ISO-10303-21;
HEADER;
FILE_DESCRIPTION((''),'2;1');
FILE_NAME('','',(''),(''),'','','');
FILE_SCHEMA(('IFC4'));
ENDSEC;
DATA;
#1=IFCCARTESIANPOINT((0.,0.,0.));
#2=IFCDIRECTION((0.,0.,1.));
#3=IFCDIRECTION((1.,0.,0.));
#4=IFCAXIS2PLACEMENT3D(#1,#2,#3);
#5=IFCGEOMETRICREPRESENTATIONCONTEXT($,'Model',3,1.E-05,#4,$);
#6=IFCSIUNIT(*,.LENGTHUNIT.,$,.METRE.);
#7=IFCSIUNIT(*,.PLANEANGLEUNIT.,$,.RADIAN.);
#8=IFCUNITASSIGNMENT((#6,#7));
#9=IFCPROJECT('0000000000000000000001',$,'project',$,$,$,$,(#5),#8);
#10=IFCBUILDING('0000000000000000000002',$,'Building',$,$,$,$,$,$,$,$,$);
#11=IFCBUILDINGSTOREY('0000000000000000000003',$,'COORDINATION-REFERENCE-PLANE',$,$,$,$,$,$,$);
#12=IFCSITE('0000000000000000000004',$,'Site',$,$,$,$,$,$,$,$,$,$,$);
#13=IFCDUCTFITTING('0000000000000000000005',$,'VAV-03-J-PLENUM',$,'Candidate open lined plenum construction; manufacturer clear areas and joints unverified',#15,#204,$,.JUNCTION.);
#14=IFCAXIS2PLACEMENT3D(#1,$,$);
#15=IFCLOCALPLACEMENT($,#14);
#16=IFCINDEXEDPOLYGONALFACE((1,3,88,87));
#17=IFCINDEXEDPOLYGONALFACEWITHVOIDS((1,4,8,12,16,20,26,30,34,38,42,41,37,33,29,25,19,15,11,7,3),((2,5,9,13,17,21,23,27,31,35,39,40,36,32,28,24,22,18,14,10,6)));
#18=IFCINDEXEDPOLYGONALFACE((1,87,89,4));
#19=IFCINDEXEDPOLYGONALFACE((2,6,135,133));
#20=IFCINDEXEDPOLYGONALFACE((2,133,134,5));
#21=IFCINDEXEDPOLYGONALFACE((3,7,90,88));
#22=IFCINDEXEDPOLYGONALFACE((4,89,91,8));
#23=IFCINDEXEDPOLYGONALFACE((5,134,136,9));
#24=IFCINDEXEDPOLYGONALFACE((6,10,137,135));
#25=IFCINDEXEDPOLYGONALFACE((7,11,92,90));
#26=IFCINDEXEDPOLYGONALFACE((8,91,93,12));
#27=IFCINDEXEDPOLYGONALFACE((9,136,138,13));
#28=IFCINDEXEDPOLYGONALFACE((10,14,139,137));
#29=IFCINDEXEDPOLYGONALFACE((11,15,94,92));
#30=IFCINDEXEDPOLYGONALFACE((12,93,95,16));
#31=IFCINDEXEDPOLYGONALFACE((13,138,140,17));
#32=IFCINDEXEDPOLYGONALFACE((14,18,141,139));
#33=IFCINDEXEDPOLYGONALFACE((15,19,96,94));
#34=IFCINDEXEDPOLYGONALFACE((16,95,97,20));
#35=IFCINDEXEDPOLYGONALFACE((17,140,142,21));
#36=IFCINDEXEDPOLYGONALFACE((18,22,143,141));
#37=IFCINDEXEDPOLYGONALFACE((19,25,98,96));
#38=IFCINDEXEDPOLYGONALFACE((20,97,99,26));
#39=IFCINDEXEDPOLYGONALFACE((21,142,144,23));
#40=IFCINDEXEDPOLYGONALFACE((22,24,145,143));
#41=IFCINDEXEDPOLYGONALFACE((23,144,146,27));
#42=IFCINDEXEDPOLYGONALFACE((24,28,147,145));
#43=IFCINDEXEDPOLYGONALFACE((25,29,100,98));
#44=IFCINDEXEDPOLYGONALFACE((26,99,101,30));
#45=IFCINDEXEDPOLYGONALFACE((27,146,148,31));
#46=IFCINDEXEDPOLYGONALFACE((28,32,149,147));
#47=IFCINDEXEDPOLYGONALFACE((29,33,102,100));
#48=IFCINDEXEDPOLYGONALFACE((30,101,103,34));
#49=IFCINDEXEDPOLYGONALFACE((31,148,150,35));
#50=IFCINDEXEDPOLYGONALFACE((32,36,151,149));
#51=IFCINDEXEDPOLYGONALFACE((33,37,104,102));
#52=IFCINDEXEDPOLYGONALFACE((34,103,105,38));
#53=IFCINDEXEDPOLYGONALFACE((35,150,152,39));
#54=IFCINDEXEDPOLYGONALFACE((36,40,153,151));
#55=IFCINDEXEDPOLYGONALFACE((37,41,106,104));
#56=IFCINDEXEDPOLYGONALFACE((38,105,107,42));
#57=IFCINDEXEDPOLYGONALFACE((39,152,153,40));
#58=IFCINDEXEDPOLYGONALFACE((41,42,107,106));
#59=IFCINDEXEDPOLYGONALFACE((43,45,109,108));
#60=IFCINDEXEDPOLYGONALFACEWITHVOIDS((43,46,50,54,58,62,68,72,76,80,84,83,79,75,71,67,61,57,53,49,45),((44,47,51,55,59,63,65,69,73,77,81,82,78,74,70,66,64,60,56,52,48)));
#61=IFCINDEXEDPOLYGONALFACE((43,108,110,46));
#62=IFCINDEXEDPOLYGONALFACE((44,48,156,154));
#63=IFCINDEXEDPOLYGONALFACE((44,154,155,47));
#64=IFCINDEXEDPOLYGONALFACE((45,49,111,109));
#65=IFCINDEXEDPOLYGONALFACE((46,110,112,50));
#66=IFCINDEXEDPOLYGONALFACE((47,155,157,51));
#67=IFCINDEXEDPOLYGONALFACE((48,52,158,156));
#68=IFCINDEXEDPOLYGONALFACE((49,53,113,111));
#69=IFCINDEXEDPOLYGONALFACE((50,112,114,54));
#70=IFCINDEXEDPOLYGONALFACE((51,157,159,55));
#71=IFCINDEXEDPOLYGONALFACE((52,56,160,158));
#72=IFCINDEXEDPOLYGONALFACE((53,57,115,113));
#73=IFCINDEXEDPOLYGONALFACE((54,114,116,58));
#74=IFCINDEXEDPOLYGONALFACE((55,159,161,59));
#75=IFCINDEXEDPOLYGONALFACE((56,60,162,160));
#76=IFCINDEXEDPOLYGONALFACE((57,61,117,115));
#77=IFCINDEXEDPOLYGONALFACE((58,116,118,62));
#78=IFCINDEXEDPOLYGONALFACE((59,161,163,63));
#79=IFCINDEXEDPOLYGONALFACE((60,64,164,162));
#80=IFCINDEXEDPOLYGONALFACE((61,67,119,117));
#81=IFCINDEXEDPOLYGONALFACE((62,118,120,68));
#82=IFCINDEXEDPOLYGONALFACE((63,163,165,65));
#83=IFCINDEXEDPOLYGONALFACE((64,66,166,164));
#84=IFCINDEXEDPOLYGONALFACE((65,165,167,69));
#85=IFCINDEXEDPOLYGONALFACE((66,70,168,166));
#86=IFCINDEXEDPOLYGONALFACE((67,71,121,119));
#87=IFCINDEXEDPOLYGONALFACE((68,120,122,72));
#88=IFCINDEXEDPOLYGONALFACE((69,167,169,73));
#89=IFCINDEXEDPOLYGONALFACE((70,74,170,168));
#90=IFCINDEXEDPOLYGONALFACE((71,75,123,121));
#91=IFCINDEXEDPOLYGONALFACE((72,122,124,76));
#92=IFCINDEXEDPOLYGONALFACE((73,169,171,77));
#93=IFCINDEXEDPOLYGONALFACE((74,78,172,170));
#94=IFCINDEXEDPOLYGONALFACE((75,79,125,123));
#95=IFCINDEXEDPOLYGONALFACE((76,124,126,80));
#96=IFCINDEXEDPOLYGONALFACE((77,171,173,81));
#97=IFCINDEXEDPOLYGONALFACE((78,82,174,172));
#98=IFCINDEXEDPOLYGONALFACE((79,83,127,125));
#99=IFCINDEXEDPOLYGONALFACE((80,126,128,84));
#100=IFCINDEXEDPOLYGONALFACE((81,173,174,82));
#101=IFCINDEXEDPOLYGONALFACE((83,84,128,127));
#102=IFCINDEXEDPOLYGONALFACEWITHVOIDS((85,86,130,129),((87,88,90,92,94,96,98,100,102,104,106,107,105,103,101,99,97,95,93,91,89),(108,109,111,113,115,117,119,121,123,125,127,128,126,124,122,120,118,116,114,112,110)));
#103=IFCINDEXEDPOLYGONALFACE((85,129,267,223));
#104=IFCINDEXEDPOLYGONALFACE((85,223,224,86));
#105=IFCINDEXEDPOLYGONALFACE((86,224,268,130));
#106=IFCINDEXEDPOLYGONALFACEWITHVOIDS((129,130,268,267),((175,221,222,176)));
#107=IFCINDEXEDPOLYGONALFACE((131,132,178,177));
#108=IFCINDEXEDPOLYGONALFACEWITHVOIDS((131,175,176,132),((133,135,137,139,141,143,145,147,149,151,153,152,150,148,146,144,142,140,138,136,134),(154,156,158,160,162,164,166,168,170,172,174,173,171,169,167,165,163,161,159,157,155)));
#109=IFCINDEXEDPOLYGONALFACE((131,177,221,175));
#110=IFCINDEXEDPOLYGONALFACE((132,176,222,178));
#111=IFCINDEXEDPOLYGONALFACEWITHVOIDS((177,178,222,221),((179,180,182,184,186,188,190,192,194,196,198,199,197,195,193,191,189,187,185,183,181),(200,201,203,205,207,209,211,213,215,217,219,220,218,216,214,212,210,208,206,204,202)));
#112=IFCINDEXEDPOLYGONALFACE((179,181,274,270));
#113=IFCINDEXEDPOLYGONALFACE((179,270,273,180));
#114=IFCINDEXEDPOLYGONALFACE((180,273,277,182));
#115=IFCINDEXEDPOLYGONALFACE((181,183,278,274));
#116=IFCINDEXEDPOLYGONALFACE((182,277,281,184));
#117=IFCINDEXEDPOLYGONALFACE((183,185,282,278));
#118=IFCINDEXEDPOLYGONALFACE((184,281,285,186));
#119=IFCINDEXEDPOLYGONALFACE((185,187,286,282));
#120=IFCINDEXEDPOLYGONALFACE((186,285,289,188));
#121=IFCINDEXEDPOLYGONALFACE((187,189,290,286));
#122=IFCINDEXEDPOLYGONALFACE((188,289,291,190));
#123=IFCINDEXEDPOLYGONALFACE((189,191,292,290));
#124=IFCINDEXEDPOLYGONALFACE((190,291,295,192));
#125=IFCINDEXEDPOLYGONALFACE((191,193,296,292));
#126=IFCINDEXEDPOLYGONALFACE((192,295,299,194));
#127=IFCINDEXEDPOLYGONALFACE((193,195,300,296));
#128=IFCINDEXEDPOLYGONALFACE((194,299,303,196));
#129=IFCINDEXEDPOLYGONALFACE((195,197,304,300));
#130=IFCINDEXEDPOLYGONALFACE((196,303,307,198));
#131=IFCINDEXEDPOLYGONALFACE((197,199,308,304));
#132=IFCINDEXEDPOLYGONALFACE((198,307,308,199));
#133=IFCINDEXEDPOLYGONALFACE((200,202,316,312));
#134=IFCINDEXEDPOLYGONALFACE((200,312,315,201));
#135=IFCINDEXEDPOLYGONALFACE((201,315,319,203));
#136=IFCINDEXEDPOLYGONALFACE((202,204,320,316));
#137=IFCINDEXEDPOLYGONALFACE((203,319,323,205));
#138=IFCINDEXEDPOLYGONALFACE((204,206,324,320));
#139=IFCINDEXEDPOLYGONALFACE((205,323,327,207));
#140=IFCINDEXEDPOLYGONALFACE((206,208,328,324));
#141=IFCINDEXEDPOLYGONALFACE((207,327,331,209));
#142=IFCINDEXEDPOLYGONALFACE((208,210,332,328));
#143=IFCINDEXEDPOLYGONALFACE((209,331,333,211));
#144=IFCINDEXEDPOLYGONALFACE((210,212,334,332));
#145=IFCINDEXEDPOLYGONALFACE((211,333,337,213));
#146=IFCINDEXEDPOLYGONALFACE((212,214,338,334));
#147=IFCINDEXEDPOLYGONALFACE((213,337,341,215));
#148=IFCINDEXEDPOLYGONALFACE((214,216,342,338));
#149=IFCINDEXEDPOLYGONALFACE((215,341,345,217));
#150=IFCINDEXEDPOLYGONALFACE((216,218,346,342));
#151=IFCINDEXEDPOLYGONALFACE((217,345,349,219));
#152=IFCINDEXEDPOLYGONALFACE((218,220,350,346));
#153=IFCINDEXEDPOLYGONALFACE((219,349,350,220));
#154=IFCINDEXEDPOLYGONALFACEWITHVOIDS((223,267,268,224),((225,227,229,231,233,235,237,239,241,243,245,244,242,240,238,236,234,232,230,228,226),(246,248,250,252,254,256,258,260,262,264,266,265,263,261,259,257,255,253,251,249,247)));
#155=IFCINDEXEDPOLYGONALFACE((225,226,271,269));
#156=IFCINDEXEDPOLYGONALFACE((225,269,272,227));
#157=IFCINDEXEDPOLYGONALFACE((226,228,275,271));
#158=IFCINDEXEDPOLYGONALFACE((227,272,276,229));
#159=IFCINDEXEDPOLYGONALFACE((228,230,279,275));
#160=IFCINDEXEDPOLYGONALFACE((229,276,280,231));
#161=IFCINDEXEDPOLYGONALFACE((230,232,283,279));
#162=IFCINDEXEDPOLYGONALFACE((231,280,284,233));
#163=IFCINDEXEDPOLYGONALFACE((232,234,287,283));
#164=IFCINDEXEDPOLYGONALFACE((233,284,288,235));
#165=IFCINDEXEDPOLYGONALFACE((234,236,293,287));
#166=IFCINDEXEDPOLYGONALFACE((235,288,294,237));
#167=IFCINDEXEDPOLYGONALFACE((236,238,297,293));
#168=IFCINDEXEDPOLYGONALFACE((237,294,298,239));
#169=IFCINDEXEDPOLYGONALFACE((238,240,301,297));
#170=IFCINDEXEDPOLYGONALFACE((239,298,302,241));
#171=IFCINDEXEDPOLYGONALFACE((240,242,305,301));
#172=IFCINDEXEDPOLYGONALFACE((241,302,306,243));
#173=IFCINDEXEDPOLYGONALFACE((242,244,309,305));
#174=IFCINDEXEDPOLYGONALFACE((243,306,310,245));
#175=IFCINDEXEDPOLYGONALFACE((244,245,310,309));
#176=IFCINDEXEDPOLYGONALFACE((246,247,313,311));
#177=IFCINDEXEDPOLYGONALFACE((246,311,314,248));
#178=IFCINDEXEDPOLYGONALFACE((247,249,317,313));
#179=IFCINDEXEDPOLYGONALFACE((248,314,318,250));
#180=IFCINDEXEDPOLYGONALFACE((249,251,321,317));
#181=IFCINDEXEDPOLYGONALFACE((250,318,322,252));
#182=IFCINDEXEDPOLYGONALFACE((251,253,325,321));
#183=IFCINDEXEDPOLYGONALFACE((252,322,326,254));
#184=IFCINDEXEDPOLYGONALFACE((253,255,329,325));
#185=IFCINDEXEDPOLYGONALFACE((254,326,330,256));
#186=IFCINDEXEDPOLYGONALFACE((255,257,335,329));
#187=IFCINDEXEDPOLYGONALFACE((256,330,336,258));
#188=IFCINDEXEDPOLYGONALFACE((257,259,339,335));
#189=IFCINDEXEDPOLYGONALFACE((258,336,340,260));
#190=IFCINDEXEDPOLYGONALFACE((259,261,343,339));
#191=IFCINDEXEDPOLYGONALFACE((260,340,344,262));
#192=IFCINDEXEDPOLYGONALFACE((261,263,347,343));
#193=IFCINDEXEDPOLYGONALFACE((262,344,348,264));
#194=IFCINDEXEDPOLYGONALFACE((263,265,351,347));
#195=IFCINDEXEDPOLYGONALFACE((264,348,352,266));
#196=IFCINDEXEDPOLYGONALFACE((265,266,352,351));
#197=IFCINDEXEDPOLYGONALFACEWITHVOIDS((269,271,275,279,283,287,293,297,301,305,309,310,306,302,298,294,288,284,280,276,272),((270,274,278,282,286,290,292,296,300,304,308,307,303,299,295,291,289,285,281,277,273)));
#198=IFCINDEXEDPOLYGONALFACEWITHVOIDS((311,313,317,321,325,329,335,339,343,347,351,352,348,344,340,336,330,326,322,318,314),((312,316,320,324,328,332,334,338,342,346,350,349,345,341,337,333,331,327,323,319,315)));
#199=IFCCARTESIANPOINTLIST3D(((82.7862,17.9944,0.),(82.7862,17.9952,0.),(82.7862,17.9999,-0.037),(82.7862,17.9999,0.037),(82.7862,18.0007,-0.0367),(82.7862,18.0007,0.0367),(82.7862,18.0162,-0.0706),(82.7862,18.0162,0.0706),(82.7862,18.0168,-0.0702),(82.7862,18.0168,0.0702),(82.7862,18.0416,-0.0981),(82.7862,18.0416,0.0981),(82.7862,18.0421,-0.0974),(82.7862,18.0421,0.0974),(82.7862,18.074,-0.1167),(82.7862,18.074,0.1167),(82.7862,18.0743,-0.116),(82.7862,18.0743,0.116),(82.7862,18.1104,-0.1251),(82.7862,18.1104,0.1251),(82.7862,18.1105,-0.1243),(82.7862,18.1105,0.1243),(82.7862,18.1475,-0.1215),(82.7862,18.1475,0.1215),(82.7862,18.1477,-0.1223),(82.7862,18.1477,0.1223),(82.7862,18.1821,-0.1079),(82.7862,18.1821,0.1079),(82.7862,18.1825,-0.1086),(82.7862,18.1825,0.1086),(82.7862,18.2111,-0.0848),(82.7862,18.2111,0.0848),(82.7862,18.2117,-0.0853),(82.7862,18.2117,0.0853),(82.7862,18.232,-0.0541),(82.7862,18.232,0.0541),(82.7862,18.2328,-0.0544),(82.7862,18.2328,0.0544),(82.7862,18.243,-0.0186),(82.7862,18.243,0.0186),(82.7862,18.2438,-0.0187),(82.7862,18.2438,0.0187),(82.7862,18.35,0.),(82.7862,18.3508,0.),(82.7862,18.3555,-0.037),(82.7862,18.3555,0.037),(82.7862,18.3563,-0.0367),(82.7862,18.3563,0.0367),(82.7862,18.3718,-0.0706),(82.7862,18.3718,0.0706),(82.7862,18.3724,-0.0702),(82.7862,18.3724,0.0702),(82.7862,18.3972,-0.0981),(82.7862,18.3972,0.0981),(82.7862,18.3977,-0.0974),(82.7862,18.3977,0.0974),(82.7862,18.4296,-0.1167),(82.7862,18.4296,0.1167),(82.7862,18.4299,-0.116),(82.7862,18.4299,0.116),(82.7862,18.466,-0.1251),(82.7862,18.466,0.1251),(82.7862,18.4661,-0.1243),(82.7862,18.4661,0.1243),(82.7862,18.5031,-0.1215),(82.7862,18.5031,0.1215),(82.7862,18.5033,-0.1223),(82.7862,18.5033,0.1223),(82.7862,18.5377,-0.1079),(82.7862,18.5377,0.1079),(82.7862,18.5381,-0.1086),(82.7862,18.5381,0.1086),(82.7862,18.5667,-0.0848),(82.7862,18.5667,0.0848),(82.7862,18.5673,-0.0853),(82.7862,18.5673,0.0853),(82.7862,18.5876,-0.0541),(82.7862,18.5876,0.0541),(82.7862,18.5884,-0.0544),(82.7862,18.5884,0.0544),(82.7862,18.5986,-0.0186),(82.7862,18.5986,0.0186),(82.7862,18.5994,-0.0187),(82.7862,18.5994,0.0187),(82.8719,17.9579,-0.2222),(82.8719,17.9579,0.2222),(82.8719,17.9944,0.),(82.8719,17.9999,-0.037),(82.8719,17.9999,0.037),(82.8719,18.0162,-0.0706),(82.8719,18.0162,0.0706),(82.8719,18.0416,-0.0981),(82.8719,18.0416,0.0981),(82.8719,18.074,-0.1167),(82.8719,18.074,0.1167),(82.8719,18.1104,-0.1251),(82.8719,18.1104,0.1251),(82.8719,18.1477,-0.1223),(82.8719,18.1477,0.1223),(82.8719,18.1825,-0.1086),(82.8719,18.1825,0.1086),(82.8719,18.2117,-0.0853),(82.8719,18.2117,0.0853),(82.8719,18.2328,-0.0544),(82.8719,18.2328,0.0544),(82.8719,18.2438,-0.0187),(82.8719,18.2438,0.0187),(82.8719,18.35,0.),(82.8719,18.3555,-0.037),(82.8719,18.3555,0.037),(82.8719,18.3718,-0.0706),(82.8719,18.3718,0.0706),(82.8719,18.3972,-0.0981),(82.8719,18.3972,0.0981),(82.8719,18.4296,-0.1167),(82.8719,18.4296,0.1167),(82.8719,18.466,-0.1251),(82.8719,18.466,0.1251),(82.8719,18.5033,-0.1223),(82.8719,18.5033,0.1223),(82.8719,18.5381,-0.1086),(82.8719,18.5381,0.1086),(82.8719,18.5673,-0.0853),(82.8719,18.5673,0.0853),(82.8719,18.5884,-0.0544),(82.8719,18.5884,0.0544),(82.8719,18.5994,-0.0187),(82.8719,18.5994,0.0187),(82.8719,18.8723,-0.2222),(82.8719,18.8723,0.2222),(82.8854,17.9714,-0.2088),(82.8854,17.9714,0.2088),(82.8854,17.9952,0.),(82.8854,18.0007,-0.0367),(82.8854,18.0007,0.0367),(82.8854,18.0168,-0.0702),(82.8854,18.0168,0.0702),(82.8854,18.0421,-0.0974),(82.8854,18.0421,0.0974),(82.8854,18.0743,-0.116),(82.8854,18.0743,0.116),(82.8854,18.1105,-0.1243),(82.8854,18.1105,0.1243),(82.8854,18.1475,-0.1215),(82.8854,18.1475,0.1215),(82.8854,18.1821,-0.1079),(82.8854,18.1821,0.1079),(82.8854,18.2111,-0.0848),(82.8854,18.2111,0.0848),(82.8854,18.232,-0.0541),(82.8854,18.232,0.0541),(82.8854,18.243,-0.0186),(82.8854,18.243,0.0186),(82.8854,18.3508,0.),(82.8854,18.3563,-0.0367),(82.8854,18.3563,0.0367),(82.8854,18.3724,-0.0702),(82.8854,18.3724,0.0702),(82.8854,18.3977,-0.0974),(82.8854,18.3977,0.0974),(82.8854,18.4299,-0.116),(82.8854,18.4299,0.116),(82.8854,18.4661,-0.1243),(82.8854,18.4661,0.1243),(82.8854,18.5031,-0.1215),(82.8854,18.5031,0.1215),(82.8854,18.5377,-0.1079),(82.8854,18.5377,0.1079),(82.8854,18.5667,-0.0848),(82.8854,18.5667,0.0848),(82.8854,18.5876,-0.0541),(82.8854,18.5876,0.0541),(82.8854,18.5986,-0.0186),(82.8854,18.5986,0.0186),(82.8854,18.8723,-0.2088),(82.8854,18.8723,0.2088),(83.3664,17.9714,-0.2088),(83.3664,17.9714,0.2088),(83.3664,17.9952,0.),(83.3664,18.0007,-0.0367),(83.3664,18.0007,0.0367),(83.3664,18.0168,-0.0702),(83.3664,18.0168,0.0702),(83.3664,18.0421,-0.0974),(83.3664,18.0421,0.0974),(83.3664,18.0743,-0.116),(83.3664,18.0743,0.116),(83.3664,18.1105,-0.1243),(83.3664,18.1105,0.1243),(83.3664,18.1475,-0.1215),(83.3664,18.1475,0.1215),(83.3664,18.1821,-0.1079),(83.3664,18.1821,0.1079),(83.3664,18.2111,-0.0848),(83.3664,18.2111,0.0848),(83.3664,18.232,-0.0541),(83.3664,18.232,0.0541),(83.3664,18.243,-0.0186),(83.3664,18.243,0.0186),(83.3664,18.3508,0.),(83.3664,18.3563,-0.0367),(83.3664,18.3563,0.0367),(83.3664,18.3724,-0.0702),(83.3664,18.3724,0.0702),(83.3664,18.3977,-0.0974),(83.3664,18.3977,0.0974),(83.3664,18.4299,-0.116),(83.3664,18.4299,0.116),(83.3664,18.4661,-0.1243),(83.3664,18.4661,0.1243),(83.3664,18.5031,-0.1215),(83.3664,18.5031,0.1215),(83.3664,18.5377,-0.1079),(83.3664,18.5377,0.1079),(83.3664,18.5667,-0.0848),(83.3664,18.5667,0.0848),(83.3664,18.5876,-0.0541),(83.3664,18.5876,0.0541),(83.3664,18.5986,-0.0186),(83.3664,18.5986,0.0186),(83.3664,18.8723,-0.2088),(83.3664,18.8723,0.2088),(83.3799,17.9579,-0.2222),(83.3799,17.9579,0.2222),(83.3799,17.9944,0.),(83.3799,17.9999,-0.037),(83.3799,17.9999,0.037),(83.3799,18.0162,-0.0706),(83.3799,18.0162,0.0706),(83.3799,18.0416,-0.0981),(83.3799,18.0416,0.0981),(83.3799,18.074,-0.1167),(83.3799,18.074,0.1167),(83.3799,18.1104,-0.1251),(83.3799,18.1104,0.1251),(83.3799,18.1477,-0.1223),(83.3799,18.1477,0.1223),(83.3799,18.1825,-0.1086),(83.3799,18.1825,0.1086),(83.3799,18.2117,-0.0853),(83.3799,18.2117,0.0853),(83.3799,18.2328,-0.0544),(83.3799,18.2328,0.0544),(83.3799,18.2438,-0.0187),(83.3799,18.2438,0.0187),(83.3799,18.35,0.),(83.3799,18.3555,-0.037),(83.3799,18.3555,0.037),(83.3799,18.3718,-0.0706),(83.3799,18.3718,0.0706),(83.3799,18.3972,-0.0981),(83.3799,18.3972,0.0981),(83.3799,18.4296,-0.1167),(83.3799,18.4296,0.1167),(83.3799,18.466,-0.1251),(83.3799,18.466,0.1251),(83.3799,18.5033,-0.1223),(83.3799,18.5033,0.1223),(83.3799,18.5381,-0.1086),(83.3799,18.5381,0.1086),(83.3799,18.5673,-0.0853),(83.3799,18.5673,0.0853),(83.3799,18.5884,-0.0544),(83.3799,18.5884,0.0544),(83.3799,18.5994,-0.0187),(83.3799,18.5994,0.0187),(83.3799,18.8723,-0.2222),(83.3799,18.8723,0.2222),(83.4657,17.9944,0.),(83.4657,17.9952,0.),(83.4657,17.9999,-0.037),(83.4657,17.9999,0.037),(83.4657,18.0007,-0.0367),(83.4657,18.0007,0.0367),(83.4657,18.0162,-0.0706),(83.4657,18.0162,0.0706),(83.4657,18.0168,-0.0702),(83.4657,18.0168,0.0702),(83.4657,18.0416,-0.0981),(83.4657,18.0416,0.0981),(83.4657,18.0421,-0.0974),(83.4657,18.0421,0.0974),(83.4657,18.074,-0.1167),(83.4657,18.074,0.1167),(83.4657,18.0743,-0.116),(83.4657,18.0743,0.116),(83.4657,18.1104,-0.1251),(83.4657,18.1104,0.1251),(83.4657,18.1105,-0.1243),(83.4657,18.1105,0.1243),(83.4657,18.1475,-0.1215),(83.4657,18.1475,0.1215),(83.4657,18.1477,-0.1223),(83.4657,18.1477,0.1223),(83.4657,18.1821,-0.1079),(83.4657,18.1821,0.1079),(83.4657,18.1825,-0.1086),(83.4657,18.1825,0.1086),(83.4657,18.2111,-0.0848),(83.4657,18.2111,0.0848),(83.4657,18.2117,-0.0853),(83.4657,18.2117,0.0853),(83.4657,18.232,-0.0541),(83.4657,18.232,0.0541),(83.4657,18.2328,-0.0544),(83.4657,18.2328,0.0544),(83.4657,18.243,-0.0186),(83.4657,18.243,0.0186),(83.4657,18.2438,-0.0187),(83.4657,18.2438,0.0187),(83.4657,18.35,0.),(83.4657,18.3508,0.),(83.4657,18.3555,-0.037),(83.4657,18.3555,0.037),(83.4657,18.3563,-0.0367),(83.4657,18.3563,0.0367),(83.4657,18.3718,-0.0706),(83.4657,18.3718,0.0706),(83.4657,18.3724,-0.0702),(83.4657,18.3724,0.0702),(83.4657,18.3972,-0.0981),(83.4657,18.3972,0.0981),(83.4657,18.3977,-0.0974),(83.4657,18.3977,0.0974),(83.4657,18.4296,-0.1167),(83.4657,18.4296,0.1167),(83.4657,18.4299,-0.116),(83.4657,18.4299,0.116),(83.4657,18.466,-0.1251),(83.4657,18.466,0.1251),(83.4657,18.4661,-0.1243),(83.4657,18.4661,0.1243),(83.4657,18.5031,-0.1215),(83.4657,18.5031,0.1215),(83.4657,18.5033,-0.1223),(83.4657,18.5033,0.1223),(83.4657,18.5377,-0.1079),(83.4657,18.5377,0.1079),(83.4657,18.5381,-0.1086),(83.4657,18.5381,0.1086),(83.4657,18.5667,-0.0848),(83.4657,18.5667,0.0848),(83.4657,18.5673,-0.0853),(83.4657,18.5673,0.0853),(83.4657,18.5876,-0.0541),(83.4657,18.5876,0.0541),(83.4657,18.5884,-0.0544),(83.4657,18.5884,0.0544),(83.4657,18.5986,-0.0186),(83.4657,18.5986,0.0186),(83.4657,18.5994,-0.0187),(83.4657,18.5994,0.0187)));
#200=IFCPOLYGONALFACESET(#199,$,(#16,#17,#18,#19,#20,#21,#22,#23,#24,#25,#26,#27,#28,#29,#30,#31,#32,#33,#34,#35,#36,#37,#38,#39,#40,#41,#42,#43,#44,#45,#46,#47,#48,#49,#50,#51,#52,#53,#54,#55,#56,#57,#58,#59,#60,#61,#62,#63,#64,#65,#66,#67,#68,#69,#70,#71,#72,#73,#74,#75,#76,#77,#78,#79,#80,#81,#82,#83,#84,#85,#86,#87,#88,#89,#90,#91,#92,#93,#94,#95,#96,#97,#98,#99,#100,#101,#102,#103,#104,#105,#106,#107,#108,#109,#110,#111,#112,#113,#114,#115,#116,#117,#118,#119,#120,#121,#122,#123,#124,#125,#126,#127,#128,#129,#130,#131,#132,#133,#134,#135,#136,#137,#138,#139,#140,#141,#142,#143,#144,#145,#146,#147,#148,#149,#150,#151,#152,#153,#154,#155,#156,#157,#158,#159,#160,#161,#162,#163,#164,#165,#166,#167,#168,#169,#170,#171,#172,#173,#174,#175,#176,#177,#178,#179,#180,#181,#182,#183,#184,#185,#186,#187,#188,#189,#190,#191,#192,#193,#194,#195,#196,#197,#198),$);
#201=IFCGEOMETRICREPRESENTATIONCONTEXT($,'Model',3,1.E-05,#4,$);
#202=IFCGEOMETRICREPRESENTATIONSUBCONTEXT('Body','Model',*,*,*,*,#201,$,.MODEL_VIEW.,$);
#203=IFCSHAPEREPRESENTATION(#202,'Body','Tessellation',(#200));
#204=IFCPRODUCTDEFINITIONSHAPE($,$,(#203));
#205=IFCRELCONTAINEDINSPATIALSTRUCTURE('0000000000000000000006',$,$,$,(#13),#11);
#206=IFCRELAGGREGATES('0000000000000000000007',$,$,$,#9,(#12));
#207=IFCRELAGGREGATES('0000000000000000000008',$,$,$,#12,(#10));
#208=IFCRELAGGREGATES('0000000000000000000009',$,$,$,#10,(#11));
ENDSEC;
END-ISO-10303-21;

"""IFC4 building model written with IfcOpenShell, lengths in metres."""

from ifc_helpers import new_model, si_unit, frame, origin_with_axes, place, context, subcontext, project, spatial, rectangle, circle, extrude, boolean, element, save


model = new_model("IFC4")

# Units and contexts
model_context_1 = context("Model", 3, precision=1e-05, world=origin_with_axes())
model_context_2 = context("Model", 3, precision=1e-05, world=origin_with_axes())
body_context_1 = subcontext(model_context_2, "Body", "Model", "MODEL_VIEW")
ifc_project = project(units=[si_unit("LENGTHUNIT", "METRE"), si_unit("PLANEANGLEUNIT", "RADIAN")], contexts=[model_context_1])

# Site, building, storey
site = spatial("IfcSite", under=ifc_project, Name="Site")
building = spatial("IfcBuilding", under=site, Name="Building")
storey = spatial("IfcBuildingStorey", under=building, Name="COORDINATION-REFERENCE-PLANE")

# Duct fitting
duct_fitting_1_placement = place(None, frame((82.8719, 17.9579, -0.2223), z_axis=(0.0, 0.0, 1.0), x_axis=(1.0, 0.0, 0.0)))
solid_1 = boolean("UNION", boolean("UNION", boolean("UNION", boolean("UNION", extrude(rectangle(XDim=0.481, YDim=0.4175), frame((0.254, 0.9244, 0.2223), z_axis=(0.0, -1.0, 0.0), x_axis=(1.0, 0.0, 0.0)), (0.0, 0.0, 1.0), 0.9109), extrude(circle(Radius=0.1246), frame((0.0235, 0.5175, 0.2223), z_axis=(-1.0, 0.0, 0.0), x_axis=(0.0, -1.0, 0.0)), (0.0, 0.0, 1.0), 0.1192)), extrude(circle(Radius=0.1246), frame((0.4845, 0.5175, 0.2223), z_axis=(1.0, 0.0, 0.0), x_axis=(0.0, -1.0, 0.0)), (0.0, 0.0, 1.0), 0.1192)), extrude(circle(Radius=0.1246), frame((0.0235, 0.1619, 0.2223), z_axis=(-1.0, 0.0, 0.0), x_axis=(0.0, -1.0, 0.0)), (0.0, 0.0, 1.0), 0.1192)), extrude(circle(Radius=0.1246), frame((0.4845, 0.1619, 0.2223), z_axis=(1.0, 0.0, 0.0), x_axis=(0.0, -1.0, 0.0)), (0.0, 0.0, 1.0), 0.1192))
element("IfcDuctFitting", 1, at=duct_fitting_1_placement, inside=storey, Name="VAV-03-J-PLENUM", ObjectType="Candidate open lined plenum construction; manufacturer clear areas and joints unverified", PredefinedType="JUNCTION", context=body_context_1, shape_type="CSG", body=[
    boolean("DIFFERENCE", boolean("UNION", boolean("UNION", boolean("UNION", boolean("UNION", extrude(rectangle(XDim=0.508, YDim=0.4445), frame((0.254, 0.9144, 0.2223), z_axis=(0.0, -1.0, 0.0), x_axis=(1.0, 0.0, 0.0)), (0.0, 0.0, 1.0), 0.9144), extrude(circle(Radius=0.1254), frame((0.0235, 0.5175, 0.2223), z_axis=(-1.0, 0.0, 0.0), x_axis=(0.0, -1.0, 0.0)), (0.0, 0.0, 1.0), 0.1092)), extrude(circle(Radius=0.1254), frame((0.4845, 0.5175, 0.2223), z_axis=(1.0, 0.0, 0.0), x_axis=(0.0, -1.0, 0.0)), (0.0, 0.0, 1.0), 0.1092)), extrude(circle(Radius=0.1254), frame((0.0235, 0.1619, 0.2223), z_axis=(-1.0, 0.0, 0.0), x_axis=(0.0, -1.0, 0.0)), (0.0, 0.0, 1.0), 0.1092)), extrude(circle(Radius=0.1254), frame((0.4845, 0.1619, 0.2223), z_axis=(1.0, 0.0, 0.0), x_axis=(0.0, -1.0, 0.0)), (0.0, 0.0, 1.0), 0.1092)), solid_1),
])

save(model, "model.ifc")
